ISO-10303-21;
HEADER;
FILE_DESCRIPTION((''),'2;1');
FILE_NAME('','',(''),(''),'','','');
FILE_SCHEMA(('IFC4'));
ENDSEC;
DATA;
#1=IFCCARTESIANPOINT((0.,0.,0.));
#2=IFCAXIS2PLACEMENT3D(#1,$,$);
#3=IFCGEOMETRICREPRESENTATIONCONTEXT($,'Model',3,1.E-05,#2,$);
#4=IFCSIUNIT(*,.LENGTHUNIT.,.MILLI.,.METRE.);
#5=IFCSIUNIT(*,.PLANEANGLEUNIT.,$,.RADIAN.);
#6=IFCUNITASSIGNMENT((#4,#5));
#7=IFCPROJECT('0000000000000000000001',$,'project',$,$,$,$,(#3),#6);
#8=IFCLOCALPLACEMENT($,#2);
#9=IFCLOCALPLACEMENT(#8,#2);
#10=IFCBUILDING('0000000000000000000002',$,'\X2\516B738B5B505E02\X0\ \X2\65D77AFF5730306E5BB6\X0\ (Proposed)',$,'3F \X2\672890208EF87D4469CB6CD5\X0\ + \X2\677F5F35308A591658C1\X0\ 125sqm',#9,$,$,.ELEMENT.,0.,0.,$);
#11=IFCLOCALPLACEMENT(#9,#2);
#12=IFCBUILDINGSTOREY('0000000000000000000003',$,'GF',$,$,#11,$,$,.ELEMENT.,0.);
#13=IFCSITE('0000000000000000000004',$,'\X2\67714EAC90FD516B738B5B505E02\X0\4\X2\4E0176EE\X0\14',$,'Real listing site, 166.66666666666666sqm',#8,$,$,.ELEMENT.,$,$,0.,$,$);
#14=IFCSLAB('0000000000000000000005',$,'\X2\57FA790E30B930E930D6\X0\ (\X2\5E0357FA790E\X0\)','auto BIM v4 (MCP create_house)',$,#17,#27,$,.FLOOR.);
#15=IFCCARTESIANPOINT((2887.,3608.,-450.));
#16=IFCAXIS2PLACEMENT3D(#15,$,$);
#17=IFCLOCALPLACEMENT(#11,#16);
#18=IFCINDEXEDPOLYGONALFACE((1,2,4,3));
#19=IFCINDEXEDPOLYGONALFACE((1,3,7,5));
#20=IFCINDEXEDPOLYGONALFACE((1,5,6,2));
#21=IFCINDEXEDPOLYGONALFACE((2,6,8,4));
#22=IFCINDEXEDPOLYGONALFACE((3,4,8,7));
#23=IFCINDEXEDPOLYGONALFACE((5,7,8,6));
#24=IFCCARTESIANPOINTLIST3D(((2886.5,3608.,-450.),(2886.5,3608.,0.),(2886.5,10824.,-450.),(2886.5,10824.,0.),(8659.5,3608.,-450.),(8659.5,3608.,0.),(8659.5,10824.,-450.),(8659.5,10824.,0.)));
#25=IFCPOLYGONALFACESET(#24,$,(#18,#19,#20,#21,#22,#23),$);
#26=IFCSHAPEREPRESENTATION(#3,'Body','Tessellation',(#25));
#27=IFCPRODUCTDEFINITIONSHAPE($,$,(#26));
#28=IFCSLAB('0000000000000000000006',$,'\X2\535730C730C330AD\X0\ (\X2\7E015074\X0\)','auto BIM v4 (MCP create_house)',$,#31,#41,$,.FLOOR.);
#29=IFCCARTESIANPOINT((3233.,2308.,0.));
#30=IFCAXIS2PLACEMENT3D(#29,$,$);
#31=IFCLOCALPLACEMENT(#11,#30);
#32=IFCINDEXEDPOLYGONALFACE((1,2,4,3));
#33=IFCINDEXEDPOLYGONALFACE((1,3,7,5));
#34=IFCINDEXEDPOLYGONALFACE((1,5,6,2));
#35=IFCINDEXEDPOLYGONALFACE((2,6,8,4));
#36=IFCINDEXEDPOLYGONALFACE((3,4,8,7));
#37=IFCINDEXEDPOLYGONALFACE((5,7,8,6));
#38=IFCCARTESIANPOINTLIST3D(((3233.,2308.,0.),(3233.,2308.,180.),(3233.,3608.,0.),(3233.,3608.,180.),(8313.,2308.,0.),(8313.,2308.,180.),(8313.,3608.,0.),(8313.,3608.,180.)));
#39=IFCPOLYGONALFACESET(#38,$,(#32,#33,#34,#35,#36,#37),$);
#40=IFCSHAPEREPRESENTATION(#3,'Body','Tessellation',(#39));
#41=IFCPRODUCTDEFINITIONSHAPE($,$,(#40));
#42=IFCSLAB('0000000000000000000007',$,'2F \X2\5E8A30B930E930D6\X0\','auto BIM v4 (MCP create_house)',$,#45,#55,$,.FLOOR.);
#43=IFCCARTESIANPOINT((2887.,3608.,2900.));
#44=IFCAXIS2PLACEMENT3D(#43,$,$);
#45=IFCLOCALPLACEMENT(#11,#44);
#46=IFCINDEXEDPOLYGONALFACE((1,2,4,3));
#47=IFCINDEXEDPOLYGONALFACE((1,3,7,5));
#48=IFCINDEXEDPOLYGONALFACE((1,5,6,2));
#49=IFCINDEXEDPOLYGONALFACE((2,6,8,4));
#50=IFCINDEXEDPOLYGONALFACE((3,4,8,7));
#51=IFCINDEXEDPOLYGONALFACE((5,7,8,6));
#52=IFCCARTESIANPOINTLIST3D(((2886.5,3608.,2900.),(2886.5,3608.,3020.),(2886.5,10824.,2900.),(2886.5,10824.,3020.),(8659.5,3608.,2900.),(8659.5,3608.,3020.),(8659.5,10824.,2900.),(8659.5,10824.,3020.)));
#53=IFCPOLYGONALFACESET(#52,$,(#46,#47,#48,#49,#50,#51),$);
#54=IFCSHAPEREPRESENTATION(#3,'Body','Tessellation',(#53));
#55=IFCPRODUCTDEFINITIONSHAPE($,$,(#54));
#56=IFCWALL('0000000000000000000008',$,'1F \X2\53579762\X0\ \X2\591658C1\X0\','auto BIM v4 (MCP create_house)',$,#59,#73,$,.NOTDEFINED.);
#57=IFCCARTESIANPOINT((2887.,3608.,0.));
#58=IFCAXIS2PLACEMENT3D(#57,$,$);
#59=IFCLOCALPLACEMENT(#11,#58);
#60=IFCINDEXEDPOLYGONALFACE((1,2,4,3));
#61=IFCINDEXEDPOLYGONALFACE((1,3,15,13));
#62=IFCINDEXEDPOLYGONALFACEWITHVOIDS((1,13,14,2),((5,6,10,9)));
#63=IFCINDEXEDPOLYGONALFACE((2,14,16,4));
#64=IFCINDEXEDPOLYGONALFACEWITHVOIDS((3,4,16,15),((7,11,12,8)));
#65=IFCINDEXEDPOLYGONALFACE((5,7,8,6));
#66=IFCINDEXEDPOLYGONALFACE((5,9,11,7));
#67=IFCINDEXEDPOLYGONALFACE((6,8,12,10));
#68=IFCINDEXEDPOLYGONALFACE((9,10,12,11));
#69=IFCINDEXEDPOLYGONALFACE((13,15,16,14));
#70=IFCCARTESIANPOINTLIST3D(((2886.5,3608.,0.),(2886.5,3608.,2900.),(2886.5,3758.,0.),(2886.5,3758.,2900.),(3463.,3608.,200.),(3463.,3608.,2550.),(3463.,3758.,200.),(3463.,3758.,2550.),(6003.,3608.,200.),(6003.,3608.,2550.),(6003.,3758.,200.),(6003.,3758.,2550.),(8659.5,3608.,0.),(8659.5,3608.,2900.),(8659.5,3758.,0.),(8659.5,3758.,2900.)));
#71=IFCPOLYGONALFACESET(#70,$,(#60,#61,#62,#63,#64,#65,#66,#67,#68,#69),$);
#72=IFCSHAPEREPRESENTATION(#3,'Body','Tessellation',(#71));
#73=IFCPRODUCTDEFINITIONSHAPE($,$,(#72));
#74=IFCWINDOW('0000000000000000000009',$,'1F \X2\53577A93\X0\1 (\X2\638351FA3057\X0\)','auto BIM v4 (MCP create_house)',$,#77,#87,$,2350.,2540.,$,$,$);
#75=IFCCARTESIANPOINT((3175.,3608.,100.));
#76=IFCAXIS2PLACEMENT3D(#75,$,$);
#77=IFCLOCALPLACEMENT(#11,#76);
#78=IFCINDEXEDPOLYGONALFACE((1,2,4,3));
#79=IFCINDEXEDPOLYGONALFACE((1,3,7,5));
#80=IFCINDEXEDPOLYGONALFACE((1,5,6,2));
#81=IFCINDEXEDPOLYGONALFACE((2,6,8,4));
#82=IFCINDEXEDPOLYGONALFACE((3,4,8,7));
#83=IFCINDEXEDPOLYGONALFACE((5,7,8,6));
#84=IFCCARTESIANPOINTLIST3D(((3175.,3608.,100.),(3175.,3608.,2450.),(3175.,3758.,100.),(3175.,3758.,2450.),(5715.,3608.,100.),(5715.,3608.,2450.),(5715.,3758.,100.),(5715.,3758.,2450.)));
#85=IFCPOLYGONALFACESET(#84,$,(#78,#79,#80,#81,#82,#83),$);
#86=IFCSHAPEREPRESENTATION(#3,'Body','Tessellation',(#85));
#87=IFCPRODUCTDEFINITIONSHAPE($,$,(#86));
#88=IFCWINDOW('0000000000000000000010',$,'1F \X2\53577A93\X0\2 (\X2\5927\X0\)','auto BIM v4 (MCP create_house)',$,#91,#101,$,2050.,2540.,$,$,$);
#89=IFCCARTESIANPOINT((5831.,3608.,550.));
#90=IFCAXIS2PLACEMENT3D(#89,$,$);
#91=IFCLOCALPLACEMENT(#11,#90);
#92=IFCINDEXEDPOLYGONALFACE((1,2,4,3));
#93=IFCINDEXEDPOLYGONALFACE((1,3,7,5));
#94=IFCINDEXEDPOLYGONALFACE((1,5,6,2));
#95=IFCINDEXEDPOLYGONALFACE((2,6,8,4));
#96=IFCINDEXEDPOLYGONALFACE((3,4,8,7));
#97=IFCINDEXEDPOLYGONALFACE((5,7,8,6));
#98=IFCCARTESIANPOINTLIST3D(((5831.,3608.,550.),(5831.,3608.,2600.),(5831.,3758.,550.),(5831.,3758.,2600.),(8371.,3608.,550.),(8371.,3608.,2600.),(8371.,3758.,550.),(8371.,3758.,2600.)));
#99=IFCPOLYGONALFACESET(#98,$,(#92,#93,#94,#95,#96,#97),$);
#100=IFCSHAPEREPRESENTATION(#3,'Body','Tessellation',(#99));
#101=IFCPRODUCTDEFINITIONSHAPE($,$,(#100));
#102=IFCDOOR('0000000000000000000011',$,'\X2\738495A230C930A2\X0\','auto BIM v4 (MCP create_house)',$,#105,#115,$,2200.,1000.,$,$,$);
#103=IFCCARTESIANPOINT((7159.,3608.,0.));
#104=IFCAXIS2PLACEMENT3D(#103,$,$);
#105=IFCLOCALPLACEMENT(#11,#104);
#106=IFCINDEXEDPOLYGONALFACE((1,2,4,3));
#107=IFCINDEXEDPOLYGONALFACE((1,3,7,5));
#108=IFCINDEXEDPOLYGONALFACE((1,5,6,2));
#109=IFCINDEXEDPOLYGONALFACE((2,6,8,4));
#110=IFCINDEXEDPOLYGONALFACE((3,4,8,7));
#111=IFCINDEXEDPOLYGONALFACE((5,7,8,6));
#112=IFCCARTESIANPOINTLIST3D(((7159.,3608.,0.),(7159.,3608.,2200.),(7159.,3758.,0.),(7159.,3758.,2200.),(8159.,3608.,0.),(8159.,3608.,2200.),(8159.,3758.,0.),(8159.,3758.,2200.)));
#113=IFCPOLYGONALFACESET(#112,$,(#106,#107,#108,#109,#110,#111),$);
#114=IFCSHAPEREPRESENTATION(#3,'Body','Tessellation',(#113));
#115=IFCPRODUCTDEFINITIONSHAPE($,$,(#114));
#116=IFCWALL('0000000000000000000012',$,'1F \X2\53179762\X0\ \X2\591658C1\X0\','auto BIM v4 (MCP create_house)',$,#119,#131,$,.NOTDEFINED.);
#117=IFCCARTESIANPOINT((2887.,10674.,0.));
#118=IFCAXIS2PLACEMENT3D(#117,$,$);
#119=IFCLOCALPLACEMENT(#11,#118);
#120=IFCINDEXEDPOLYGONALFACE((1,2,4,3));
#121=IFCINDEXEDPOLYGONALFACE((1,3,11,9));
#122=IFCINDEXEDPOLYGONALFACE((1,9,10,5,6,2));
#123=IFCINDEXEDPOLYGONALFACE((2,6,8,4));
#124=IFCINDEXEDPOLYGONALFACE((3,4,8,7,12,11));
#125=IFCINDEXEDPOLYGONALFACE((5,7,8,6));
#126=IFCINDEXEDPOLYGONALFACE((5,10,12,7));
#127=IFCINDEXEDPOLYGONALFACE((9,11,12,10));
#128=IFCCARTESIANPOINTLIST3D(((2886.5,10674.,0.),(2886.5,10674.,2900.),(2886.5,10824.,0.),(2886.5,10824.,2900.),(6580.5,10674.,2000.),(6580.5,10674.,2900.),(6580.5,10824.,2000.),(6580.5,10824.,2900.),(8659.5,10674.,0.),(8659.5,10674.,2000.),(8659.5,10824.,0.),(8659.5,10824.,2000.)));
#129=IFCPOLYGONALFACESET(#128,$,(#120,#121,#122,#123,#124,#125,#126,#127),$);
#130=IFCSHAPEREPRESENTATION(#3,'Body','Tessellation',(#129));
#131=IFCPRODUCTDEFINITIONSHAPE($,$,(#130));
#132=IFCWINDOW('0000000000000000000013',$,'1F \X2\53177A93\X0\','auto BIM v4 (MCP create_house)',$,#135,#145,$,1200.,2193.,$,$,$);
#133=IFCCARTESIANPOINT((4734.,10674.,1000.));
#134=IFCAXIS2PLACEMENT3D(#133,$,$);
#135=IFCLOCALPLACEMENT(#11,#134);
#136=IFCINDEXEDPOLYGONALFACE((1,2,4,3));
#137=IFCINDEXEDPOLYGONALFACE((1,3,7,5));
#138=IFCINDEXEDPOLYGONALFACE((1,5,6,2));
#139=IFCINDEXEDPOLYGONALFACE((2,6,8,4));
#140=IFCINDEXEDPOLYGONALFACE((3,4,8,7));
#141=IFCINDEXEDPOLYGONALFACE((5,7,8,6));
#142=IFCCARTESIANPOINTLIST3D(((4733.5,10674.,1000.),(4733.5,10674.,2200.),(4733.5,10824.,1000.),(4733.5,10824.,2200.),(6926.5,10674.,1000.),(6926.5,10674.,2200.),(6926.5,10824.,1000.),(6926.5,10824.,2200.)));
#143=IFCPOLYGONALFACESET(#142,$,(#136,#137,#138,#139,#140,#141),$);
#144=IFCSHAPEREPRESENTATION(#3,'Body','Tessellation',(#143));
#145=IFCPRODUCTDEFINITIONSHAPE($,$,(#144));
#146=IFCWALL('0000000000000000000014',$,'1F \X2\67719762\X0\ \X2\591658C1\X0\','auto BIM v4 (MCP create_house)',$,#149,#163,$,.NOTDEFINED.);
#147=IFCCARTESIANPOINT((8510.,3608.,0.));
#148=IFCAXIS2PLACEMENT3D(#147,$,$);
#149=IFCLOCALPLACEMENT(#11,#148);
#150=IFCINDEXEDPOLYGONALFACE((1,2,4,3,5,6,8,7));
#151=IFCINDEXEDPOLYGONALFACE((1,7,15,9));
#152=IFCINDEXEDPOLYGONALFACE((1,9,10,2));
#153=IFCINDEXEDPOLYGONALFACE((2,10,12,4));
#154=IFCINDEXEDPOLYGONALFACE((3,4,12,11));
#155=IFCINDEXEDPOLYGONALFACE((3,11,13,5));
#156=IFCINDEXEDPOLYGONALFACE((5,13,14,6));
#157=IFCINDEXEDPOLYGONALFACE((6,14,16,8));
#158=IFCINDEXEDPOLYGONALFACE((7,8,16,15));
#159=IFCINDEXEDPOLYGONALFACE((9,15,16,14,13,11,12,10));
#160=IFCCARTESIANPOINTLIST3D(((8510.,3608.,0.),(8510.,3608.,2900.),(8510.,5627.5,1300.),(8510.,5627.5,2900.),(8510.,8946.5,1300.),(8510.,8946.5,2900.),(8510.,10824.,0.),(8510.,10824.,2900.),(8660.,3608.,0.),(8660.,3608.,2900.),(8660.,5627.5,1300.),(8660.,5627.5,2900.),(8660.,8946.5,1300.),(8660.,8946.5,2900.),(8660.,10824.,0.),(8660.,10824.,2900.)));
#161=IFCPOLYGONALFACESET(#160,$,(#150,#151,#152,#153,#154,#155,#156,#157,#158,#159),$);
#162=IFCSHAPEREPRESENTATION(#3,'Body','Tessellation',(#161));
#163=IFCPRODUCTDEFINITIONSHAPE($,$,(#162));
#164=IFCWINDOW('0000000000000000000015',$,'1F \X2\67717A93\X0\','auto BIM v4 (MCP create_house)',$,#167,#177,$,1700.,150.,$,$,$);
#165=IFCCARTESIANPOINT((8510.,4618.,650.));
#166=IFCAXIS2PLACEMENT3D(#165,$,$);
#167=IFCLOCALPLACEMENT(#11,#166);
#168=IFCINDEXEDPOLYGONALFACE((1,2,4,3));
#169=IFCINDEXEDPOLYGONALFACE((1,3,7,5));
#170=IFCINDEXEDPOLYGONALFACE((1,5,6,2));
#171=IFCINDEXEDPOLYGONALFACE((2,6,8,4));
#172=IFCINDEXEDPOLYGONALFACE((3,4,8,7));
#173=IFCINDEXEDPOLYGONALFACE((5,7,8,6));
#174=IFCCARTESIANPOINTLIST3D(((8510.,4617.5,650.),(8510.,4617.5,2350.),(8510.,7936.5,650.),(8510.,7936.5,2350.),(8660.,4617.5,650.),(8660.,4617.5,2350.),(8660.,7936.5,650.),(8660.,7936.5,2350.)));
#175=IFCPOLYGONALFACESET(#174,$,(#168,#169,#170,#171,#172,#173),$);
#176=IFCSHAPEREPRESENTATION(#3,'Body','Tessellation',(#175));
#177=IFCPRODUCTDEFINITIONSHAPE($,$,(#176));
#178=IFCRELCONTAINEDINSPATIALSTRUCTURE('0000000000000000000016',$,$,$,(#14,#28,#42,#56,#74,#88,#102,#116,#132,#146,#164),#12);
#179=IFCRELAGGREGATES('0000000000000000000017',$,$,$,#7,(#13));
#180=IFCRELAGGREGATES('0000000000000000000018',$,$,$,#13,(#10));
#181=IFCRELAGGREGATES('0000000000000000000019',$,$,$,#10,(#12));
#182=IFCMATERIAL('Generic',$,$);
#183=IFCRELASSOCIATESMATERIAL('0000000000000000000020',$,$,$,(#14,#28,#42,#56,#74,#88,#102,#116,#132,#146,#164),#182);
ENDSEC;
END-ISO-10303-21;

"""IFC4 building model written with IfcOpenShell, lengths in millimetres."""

from ifc_helpers import new_model, si_unit, frame, frame_2d, origin, place, context, project, spatial, rectangle, extrude, material, element, fill, save


model = new_model("IFC4")

# Units and contexts
model_context = context("Model", 3, precision=1e-05, world=origin())
ifc_project = project(units=[si_unit("LENGTHUNIT", "METRE", prefix="MILLI"), si_unit("PLANEANGLEUNIT", "RADIAN")], contexts=[model_context])

# Site, building, storey
site_placement = place(None, origin())
site = spatial("IfcSite", under=ifc_project, at=site_placement, Name="東京都八王子市4丁目14", ObjectType="Real listing site, 166.66666666666666sqm", CompositionType="ELEMENT", RefElevation=0.0)
building_placement = place(site_placement, origin())
building = spatial("IfcBuilding", under=site, at=building_placement, Name="八王子市 旗竿地の家 (Proposed)", ObjectType="3F 木造軸組構法 + 板張り外壁 125sqm", CompositionType="ELEMENT", ElevationOfRefHeight=0.0, ElevationOfTerrain=0.0)
storey_placement = place(building_placement, origin())
storey = spatial("IfcBuildingStorey", under=building, at=storey_placement, Name="GF", CompositionType="ELEMENT", Elevation=0.0)

# Slabs
ifc_material = material(Name="Generic")
slab_1_placement = place(storey_placement, frame((2887.0, 3608.0, -450.0)))
element("IfcSlab", 1, at=slab_1_placement, inside=storey, material=ifc_material, Name="基礎スラブ (布基礎)", Description="auto BIM v4 (MCP create_house)", PredefinedType="FLOOR", context=model_context, shape_type="SweptSolid", body=[
    extrude(rectangle(XDim=5773.0, YDim=7216.0, at=frame_2d((2886.0, 3608.0))), frame((2887.0, 3608.0, -450.0)), (0.0, 0.0, 1.0), 450.0),
])
slab_2_placement = place(storey_placement, frame((3233.0, 2308.0, 0.0)))
element("IfcSlab", 2, at=slab_2_placement, inside=storey, material=ifc_material, Name="南デッキ (縁側)", Description="auto BIM v4 (MCP create_house)", PredefinedType="FLOOR", context=model_context, shape_type="SweptSolid", body=[
    extrude(rectangle(XDim=5080.0, YDim=1300.0, at=frame_2d((2540.0, 650.0))), frame((3233.0, 2308.0, 0.0)), (0.0, 0.0, 1.0), 180.0),
])
slab_3_placement = place(storey_placement, frame((2887.0, 3608.0, 2900.0)))
element("IfcSlab", 3, at=slab_3_placement, inside=storey, material=ifc_material, Name="2F 床スラブ", Description="auto BIM v4 (MCP create_house)", PredefinedType="FLOOR", context=model_context, shape_type="SweptSolid", body=[
    extrude(rectangle(XDim=5773.0, YDim=7216.0, at=frame_2d((2886.0, 3608.0))), frame((2887.0, 3608.0, 2900.0)), (0.0, 0.0, 1.0), 120.0),
])

# Wall, openings, windows, door
wall_1_placement = place(storey_placement, frame((2887.0, 3608.0, 0.0)))
wall_1 = element("IfcWall", 4, at=wall_1_placement, inside=storey, material=ifc_material, Name="1F 南面 外壁", Description="auto BIM v4 (MCP create_house)", PredefinedType="NOTDEFINED", context=model_context, shape_type="SweptSolid", body=[
    extrude(rectangle(XDim=5773.0, YDim=150.0, at=frame_2d((2886.0, 75.0))), frame((2887.0, 3608.0, 0.0)), (0.0, 0.0, 1.0), 2900.0),
])
opening_1_placement = place(storey_placement, frame((3175.0, 3608.0, 100.0)))
opening_1 = element("IfcOpeningElement", 5, at=opening_1_placement, cuts=wall_1, PredefinedType="NOTDEFINED", context=model_context, shape_type="SweptSolid", body=[
    extrude(rectangle(XDim=2540.0, YDim=150.0, at=frame_2d((1270.0, 75.0))), frame((3175.0, 3608.0, 100.0)), (0.0, 0.0, 1.0), 2350.0),
])
opening_2_placement = place(storey_placement, frame((5831.0, 3608.0, 550.0)))
opening_2 = element("IfcOpeningElement", 6, at=opening_2_placement, cuts=wall_1, PredefinedType="NOTDEFINED", context=model_context, shape_type="SweptSolid", body=[
    extrude(rectangle(XDim=2540.0, YDim=150.0, at=frame_2d((1270.0, 75.0))), frame((5831.0, 3608.0, 550.0)), (0.0, 0.0, 1.0), 2050.0),
])
opening_3_placement = place(storey_placement, frame((7159.0, 3608.0, 0.0)))
opening_3 = element("IfcOpeningElement", 7, at=opening_3_placement, cuts=wall_1, PredefinedType="NOTDEFINED", context=model_context, shape_type="SweptSolid", body=[
    extrude(rectangle(XDim=1000.0, YDim=150.0, at=frame_2d((500.0, 75.0))), frame((7159.0, 3608.0, 0.0)), (0.0, 0.0, 1.0), 2200.0),
])
window_1_placement = place(storey_placement, frame((3175.0, 3608.0, 100.0)))
window_1 = element("IfcWindow", 8, at=window_1_placement, inside=storey, material=ifc_material, Name="1F 南窓1 (掃出し)", Description="auto BIM v4 (MCP create_house)", OverallHeight=2350.0, OverallWidth=2540.0, context=model_context, shape_type="SweptSolid", body=[
    extrude(rectangle(XDim=2540.0, YDim=150.0, at=frame_2d((1270.0, 75.0))), frame((3175.0, 3608.0, 100.0)), (0.0, 0.0, 1.0), 2350.0),
])
fill(opening_1, window_1)
window_2_placement = place(storey_placement, frame((5831.0, 3608.0, 550.0)))
window_2 = element("IfcWindow", 9, at=window_2_placement, inside=storey, material=ifc_material, Name="1F 南窓2 (大)", Description="auto BIM v4 (MCP create_house)", OverallHeight=2050.0, OverallWidth=2540.0, context=model_context, shape_type="SweptSolid", body=[
    extrude(rectangle(XDim=2540.0, YDim=150.0, at=frame_2d((1270.0, 75.0))), frame((5831.0, 3608.0, 550.0)), (0.0, 0.0, 1.0), 2050.0),
])
fill(opening_2, window_2)
door_placement = place(storey_placement, frame((7159.0, 3608.0, 0.0)))
door = element("IfcDoor", 10, at=door_placement, inside=storey, material=ifc_material, Name="玄関ドア", Description="auto BIM v4 (MCP create_house)", OverallHeight=2200.0, OverallWidth=1000.0, context=model_context, shape_type="SweptSolid", body=[
    extrude(rectangle(XDim=1000.0, YDim=150.0, at=frame_2d((500.0, 75.0))), frame((7159.0, 3608.0, 0.0)), (0.0, 0.0, 1.0), 2200.0),
])
fill(opening_3, door)

# Walls, openings, windows
wall_2_placement = place(storey_placement, frame((2887.0, 10674.0, 0.0)))
wall_2 = element("IfcWall", 11, at=wall_2_placement, inside=storey, material=ifc_material, Name="1F 北面 外壁", Description="auto BIM v4 (MCP create_house)", PredefinedType="NOTDEFINED", context=model_context, shape_type="SweptSolid", body=[
    extrude(rectangle(XDim=5773.0, YDim=150.0, at=frame_2d((2886.0, 75.0))), frame((2887.0, 10674.0, 0.0)), (0.0, 0.0, 1.0), 2900.0),
])
opening_4_placement = place(storey_placement, frame((4734.0, 10674.0, 1000.0)))
opening_4 = element("IfcOpeningElement", 12, at=opening_4_placement, cuts=wall_2, PredefinedType="NOTDEFINED", context=model_context, shape_type="SweptSolid", body=[
    extrude(rectangle(XDim=2193.0, YDim=150.0, at=frame_2d((1096.0, 75.0))), frame((4734.0, 10674.0, 1000.0)), (0.0, 0.0, 1.0), 1200.0),
])
window_3_placement = place(storey_placement, frame((4734.0, 10674.0, 1000.0)))
window_3 = element("IfcWindow", 13, at=window_3_placement, inside=storey, material=ifc_material, Name="1F 北窓", Description="auto BIM v4 (MCP create_house)", OverallHeight=1200.0, OverallWidth=2193.0, context=model_context, shape_type="SweptSolid", body=[
    extrude(rectangle(XDim=2193.0, YDim=150.0, at=frame_2d((1096.0, 75.0))), frame((4734.0, 10674.0, 1000.0)), (0.0, 0.0, 1.0), 1200.0),
])
fill(opening_4, window_3)
wall_3_placement = place(storey_placement, frame((8510.0, 3608.0, 0.0)))
wall_3 = element("IfcWall", 14, at=wall_3_placement, inside=storey, material=ifc_material, Name="1F 東面 外壁", Description="auto BIM v4 (MCP create_house)", PredefinedType="NOTDEFINED", context=model_context, shape_type="SweptSolid", body=[
    extrude(rectangle(XDim=150.0, YDim=7216.0, at=frame_2d((75.0, 3608.0))), frame((8510.0, 3608.0, 0.0)), (0.0, 0.0, 1.0), 2900.0),
])
opening_5_placement = place(storey_placement, frame((8510.0, 4618.0, 650.0)))
opening_5 = element("IfcOpeningElement", 15, at=opening_5_placement, cuts=wall_3, PredefinedType="NOTDEFINED", context=model_context, shape_type="SweptSolid", body=[
    extrude(rectangle(XDim=150.0, YDim=3319.0, at=frame_2d((75.0, 1659.0))), frame((8510.0, 4618.0, 650.0)), (0.0, 0.0, 1.0), 1700.0),
])
window_4_placement = place(storey_placement, frame((8510.0, 4618.0, 650.0)))
window_4 = element("IfcWindow", 16, at=window_4_placement, inside=storey, material=ifc_material, Name="1F 東窓", Description="auto BIM v4 (MCP create_house)", OverallHeight=1700.0, OverallWidth=150.0, context=model_context, shape_type="SweptSolid", body=[
    extrude(rectangle(XDim=150.0, YDim=3319.0, at=frame_2d((75.0, 1659.0))), frame((8510.0, 4618.0, 650.0)), (0.0, 0.0, 1.0), 1700.0),
])
fill(opening_5, window_4)

save(model, "model.ifc")
